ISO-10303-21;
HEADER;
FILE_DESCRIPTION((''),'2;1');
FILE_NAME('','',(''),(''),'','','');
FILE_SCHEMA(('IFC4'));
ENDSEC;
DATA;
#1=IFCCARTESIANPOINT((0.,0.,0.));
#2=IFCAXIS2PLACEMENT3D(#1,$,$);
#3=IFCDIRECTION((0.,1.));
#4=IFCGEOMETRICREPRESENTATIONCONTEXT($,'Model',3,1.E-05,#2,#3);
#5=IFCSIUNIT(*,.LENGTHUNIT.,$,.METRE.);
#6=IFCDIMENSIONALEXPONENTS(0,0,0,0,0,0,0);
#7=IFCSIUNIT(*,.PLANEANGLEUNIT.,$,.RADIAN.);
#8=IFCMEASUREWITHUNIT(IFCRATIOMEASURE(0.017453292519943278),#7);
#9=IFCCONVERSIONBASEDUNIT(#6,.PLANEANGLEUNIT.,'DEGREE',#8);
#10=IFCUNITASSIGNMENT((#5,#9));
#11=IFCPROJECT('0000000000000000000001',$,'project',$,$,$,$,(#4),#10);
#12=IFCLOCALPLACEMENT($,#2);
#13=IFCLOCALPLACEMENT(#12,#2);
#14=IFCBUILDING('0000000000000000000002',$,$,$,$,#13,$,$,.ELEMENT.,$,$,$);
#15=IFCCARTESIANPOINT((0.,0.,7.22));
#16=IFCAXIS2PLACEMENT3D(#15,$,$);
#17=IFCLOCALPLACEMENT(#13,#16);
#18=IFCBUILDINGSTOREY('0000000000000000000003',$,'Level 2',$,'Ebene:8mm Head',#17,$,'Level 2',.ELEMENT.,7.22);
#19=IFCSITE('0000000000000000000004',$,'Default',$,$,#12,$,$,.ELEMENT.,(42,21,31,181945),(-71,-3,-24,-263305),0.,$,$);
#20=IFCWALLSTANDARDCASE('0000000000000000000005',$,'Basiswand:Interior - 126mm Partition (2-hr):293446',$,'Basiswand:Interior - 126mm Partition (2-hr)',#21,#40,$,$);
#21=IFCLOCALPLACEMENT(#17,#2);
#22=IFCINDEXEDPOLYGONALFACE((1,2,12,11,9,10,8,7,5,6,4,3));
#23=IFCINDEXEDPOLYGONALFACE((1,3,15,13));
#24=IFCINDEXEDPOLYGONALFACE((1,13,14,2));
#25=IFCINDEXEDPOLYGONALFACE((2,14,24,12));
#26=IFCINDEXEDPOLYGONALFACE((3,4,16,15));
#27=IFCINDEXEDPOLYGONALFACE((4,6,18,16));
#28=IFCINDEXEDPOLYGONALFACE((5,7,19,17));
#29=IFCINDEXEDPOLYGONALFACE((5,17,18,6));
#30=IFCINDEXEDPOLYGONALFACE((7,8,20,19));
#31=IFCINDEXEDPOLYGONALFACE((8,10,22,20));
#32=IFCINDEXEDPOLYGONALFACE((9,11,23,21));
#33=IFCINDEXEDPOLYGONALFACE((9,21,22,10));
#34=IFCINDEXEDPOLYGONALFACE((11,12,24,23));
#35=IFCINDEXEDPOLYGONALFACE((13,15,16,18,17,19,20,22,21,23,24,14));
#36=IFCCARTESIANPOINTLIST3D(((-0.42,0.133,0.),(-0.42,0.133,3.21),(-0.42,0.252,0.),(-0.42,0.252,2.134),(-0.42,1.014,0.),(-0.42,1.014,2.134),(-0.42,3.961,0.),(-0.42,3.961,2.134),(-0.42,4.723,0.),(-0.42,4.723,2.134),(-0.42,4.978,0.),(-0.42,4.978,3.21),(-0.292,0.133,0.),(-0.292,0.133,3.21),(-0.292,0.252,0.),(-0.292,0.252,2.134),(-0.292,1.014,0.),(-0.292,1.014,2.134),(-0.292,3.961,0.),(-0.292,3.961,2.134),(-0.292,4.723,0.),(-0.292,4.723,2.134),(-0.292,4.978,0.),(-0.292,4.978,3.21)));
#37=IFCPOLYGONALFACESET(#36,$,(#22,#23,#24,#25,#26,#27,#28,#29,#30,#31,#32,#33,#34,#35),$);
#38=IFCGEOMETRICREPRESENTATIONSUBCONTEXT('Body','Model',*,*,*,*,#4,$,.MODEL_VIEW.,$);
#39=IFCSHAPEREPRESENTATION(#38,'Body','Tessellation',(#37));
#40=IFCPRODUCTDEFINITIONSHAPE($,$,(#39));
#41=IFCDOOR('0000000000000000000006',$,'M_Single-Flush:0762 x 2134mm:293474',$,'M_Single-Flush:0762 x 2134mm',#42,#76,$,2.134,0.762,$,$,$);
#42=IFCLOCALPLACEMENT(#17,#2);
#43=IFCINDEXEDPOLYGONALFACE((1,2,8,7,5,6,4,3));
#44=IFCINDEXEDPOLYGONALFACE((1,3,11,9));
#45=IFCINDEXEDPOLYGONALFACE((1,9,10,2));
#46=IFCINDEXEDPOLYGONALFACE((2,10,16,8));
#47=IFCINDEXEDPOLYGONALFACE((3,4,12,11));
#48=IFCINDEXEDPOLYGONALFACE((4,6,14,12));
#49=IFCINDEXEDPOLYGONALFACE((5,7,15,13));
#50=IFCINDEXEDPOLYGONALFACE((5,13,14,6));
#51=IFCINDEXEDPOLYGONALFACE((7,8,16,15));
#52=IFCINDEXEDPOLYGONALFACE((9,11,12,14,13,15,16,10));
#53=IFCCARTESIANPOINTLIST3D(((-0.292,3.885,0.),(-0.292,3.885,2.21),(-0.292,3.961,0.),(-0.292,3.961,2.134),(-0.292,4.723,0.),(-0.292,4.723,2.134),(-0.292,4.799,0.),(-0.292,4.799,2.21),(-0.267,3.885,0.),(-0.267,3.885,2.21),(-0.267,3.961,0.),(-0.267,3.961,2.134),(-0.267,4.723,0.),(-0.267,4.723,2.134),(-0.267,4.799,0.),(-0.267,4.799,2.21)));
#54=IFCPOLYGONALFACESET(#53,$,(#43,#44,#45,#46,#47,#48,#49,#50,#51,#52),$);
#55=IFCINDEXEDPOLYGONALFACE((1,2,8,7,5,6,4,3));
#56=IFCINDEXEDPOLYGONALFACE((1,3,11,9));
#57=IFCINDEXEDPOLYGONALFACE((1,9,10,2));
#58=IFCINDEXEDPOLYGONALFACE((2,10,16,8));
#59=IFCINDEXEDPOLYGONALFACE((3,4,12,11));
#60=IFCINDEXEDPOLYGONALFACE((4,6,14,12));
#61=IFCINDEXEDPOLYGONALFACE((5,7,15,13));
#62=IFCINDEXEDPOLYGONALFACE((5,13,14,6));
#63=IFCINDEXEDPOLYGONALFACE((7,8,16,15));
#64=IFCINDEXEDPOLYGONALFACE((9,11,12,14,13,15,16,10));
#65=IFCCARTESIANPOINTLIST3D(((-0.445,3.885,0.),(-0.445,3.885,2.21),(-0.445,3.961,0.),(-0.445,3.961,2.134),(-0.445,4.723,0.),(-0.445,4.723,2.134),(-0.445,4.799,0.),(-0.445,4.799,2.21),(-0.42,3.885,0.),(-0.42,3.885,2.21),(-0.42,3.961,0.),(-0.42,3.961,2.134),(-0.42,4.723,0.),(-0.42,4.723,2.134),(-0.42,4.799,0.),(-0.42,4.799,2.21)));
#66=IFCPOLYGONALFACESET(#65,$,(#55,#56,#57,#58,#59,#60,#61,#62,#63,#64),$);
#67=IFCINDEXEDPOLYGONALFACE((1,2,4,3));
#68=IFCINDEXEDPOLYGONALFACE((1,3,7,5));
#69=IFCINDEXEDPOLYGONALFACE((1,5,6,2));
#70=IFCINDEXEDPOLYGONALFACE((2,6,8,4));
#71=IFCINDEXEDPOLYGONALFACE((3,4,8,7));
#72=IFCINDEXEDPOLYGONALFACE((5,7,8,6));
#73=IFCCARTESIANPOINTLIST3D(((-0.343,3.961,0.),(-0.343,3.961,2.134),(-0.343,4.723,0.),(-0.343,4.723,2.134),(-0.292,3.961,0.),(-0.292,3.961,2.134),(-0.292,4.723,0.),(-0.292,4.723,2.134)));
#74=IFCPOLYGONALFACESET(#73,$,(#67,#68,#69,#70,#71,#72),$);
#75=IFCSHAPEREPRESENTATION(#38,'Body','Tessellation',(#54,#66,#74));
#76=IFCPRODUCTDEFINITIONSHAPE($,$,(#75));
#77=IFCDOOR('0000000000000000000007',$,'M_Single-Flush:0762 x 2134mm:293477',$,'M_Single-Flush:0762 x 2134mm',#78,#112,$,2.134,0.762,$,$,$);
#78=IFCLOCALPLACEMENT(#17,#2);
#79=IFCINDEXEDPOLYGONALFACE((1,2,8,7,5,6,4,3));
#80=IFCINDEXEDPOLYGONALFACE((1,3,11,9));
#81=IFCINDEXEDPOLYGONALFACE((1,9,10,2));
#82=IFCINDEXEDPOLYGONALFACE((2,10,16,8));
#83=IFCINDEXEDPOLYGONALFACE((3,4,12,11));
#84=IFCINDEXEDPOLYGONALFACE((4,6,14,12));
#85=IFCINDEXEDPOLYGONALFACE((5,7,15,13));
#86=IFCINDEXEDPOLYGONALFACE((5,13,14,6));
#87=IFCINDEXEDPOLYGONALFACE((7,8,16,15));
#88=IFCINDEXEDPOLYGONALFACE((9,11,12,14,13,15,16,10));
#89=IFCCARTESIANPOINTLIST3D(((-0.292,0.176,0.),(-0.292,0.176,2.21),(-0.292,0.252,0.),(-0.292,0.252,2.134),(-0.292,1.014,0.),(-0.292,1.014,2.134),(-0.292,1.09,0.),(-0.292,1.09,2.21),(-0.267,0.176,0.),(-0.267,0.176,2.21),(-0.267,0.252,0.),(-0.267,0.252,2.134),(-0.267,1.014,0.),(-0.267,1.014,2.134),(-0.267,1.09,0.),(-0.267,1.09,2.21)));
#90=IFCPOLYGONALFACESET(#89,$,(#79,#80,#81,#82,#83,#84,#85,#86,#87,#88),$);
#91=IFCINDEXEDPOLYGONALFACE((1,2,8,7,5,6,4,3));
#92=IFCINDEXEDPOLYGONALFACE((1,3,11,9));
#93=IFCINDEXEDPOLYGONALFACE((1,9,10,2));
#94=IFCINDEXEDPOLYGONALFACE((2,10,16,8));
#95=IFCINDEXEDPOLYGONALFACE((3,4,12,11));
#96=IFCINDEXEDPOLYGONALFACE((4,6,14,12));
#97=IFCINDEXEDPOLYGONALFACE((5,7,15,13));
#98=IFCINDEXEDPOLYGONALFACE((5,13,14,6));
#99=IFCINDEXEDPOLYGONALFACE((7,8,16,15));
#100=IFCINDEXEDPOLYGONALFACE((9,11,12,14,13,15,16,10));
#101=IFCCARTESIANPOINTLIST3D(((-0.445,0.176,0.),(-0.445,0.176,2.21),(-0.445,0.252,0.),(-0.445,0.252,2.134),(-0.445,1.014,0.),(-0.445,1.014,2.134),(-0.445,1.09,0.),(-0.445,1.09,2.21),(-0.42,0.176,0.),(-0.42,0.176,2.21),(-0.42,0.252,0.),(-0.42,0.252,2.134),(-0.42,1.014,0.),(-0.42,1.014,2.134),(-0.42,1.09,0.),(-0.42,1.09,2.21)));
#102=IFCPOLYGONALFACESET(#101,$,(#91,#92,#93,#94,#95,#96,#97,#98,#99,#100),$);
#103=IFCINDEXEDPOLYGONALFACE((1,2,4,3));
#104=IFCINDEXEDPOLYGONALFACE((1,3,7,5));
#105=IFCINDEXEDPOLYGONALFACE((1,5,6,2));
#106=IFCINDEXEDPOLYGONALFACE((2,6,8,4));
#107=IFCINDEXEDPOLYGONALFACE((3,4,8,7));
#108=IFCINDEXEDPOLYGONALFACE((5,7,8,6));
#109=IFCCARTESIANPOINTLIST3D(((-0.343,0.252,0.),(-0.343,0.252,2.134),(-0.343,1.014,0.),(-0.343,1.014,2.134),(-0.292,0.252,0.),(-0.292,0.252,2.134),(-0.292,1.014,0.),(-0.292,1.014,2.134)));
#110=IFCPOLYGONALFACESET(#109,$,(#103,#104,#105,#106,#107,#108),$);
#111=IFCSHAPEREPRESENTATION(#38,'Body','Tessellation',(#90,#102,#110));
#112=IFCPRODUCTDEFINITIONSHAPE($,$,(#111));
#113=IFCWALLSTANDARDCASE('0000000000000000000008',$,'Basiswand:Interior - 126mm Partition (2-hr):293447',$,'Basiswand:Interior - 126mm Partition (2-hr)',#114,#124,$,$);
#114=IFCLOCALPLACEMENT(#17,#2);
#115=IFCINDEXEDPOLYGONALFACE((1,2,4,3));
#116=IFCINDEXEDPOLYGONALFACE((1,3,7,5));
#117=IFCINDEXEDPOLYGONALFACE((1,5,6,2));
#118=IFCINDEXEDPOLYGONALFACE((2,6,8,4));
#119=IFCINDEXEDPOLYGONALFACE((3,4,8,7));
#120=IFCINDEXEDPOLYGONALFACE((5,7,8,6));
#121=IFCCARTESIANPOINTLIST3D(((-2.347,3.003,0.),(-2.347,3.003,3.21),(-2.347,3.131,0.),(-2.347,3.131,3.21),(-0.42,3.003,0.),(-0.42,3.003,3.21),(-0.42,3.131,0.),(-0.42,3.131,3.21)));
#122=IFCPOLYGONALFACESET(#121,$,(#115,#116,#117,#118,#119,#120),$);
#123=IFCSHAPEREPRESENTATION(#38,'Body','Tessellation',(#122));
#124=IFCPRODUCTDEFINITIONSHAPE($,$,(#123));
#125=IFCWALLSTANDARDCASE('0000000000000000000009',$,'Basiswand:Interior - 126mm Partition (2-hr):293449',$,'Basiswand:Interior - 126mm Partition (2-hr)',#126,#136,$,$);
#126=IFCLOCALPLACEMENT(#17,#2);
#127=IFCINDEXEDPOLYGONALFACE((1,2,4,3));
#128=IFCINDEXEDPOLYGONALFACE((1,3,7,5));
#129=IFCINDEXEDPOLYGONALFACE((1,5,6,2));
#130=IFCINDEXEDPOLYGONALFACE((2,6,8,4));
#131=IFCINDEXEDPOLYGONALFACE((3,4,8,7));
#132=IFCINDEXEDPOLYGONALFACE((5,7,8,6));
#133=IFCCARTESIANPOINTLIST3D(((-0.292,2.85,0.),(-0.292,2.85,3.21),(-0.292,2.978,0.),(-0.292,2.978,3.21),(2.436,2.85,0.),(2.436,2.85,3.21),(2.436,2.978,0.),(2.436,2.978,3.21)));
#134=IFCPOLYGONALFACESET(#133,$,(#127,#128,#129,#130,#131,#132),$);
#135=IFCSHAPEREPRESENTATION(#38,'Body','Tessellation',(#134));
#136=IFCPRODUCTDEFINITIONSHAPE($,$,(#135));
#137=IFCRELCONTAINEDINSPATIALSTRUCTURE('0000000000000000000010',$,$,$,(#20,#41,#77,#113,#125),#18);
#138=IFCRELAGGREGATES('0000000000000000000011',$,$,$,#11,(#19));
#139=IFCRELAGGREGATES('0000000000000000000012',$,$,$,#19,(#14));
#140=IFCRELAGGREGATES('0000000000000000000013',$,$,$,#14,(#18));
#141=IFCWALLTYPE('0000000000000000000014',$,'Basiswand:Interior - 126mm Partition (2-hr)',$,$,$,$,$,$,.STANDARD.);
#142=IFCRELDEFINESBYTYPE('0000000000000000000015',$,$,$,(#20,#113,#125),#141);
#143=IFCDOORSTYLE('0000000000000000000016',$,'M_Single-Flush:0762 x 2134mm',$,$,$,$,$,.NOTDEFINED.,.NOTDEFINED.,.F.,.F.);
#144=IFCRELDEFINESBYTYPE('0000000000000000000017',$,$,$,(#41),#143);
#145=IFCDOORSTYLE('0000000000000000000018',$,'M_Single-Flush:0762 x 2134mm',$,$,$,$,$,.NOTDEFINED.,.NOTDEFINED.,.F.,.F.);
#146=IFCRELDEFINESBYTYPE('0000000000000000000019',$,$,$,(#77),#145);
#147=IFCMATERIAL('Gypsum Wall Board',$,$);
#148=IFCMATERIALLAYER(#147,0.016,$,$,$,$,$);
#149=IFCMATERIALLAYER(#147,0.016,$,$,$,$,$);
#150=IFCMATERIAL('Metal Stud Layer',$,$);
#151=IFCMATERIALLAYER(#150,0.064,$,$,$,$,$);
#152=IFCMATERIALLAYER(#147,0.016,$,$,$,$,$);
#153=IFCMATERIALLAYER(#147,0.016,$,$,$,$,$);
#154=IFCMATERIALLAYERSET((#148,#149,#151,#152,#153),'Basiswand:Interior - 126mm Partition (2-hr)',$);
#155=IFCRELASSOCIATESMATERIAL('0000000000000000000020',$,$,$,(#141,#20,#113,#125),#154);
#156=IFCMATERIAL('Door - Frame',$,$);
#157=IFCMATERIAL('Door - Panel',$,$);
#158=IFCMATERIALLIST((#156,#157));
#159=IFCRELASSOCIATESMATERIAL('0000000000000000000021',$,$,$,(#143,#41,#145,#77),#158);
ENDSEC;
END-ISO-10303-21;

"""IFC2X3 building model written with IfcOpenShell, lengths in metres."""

from ifc_helpers import new_model, entity, si_unit, converted_unit, direction, frame, frame_2d, origin, place, context, subcontext, project, spatial, polyline, rectangle, outline, extrude, clip, bounded_halfspace, source, transform, mapped, material, material_list, layer, layer_set, layer_usage, type_object, type_shapes, element, fill, save


model = new_model("IFC2X3")

# Units and contexts
model_context = context("Model", 3, precision=1e-05, world=origin(), true_north=direction((0.0, 1.0)))
body_context = subcontext(model_context, "Body", "Model", "MODEL_VIEW")
ifc_project = project(units=[si_unit("LENGTHUNIT", "METRE"), converted_unit("PLANEANGLEUNIT", "DEGREE", entity("IfcRatioMeasure", 0.017453292519943278), si_unit("PLANEANGLEUNIT", "RADIAN"), dimensions=[0, 0, 0, 0, 0, 0, 0])], contexts=[model_context])

# Site, building, storey
site_placement = place(None, origin())
site = spatial("IfcSite", under=ifc_project, at=site_placement, Name="Default", CompositionType="ELEMENT", RefLatitude=(42, 21, 31, 181945), RefLongitude=(-71, -3, -24, -263305), RefElevation=0.0)
building_placement = place(site_placement, origin())
building = spatial("IfcBuilding", under=site, at=building_placement, CompositionType="ELEMENT")
storey_placement = place(building_placement, frame((0.0, 0.0, 7.22)))
storey = spatial("IfcBuildingStorey", under=building, at=storey_placement, Name="Level 2", ObjectType="Ebene:8mm Head", LongName="Level 2", CompositionType="ELEMENT", Elevation=7.22)

# Shared definitions
ifc_material_1 = material(Name="Gypsum Wall Board")
ifc_layer_1 = layer(ifc_material_1, 0.016)
ifc_layer_2 = layer(ifc_material_1, 0.016)
ifc_material_2 = material(Name="Metal Stud Layer")
ifc_layer_3 = layer(ifc_material_2, 0.064)
ifc_layer_4 = layer(ifc_material_1, 0.016)
ifc_layer_5 = layer(ifc_material_1, 0.016)
ifc_layer_set = layer_set([ifc_layer_1, ifc_layer_2, ifc_layer_3, ifc_layer_4, ifc_layer_5], Name="Basiswand:Interior - 126mm Partition (2-hr)")
ifc_layer_usage_1 = layer_usage(ifc_layer_set, "AXIS2", "NEGATIVE", 0.064)
wall_type = type_object("IfcWallType", Name="Basiswand:Interior - 126mm Partition (2-hr)", PredefinedType="STANDARD", material=ifc_layer_set)
ifc_material_3 = material(Name="Door - Frame")
ifc_material_4 = material(Name="Door - Panel")
ifc_material_list = material_list([ifc_material_3, ifc_material_4])
door_style_1 = type_object("IfcDoorStyle", Name="M_Single-Flush:0762 x 2134mm", ConstructionType="NOTDEFINED", OperationType="NOTDEFINED", ParameterTakesPrecedence=False, Sizeable=False, material=ifc_material_list)
shared_shape_1 = source(origin(), body_context, "Body", "SweptSolid", [
    extrude(outline(polyline([(-0.457, -1.124), (0.457, -1.124), (0.457, 1.086), (0.381, 1.086), (0.381, -1.048), (-0.381, -1.048), (-0.381, 1.086), (-0.457, 1.086), (-0.457, -1.124)])), frame((0.381, 0.153, 1.086), z_axis=(0.0, -1.0, 0.0), x_axis=(-1.0, 0.0, 0.0)), (0.0, 0.0, 1.0), 0.025),
    extrude(outline(polyline([(-1.124, -0.457), (1.086, -0.457), (1.086, -0.381), (-1.048, -0.381), (-1.048, 0.381), (1.086, 0.381), (1.086, 0.457), (-1.124, 0.457), (-1.124, -0.457)])), frame((0.381, 0.0, 1.086), z_axis=(0.0, -1.0, 0.0), x_axis=(0.0, 0.0, -1.0)), (0.0, 0.0, 1.0), 0.025),
    extrude(rectangle(XDim=0.762, YDim=0.051, at=frame_2d((0.0, 0.0), x_axis=(1.0, 0.0))), frame((0.381, 0.1025, 0.0)), (0.0, 0.0, 1.0), 2.134),
])
type_shapes(door_style_1, [shared_shape_1])

# Wall, openings, doors
ifc_layer_usage_2 = layer_usage(ifc_layer_set, "AXIS2", "POSITIVE", -0.064)
wall_1_placement = place(storey_placement, frame((-0.356, 4.978, 0.0), z_axis=(0.0, 0.0, 1.0), x_axis=(0.0, -1.0, 0.0)))
wall_1 = element("IfcWallStandardCase", 1, at=wall_1_placement, inside=storey, type_object=wall_type, material=ifc_layer_usage_2, Name="Basiswand:Interior - 126mm Partition (2-hr):293446", ObjectType="Basiswand:Interior - 126mm Partition (2-hr)", context=body_context, shape_type="Clipping", body=[
    clip(extrude(rectangle(XDim=4.845, YDim=0.128, at=frame_2d((2.4225, 0.0), x_axis=(1.0, 0.0))), origin(), (0.0, 0.0, 1.0), 3.21), bounded_halfspace(frame((0.0, -0.064, 3.21), z_axis=(0.0, 0.0, -1.0), x_axis=(-1.0, 0.0, 0.0)), True, frame((0.0, -0.064, 3.21)), polyline([(0.0, 0.0), (1.847, 0.0), (1.975, 0.0), (2.975, 0.0), (3.103, 0.0), (4.845, 0.0), (4.845, 0.128), (2.128, 0.128), (2.0, 0.128), (0.0, 0.128), (0.0, 0.0)]))),
])
opening_1_placement = place(wall_1_placement, frame((0.255, -0.064, 0.0)))
opening_1 = element("IfcOpeningElement", 2, at=opening_1_placement, cuts=wall_1, ObjectType="Opening", context=body_context, shape_type="SweptSolid", body=[
    extrude(rectangle(XDim=0.762, YDim=2.134, at=frame_2d((1.067, 0.381), x_axis=(0.0, -1.0))), frame((0.0, 0.0, 0.0), z_axis=(0.0, 1.0, 0.0), x_axis=(0.0, 0.0, 1.0)), (0.0, 0.0, 1.0), 0.128),
])
opening_2_placement = place(wall_1_placement, frame((3.964, -0.064, 0.0)))
opening_2 = element("IfcOpeningElement", 3, at=opening_2_placement, cuts=wall_1, ObjectType="Opening", context=body_context, shape_type="SweptSolid", body=[
    extrude(rectangle(XDim=0.762, YDim=2.134, at=frame_2d((1.067, 0.381), x_axis=(0.0, 1.0))), frame((0.0, 0.0, 0.0), z_axis=(0.0, 1.0, 0.0), x_axis=(0.0, 0.0, 1.0)), (0.0, 0.0, 1.0), 0.128),
])
door_1_placement = place(opening_1_placement, origin())
door_1 = element("IfcDoor", 4, at=door_1_placement, inside=storey, type_object=door_style_1, material=ifc_material_list, Name="M_Single-Flush:0762 x 2134mm:293474", ObjectType="M_Single-Flush:0762 x 2134mm", OverallHeight=2.134, OverallWidth=0.762, context=body_context, shape_type="MappedRepresentation", body=[
    mapped(shared_shape_1, transform((0.0, 0.0, 0.0), scale=1.0)),
])
fill(opening_1, door_1)
door_style_2 = type_object("IfcDoorStyle", Name="M_Single-Flush:0762 x 2134mm", ConstructionType="NOTDEFINED", OperationType="NOTDEFINED", ParameterTakesPrecedence=False, Sizeable=False, material=ifc_material_list)
shared_shape_2 = source(origin(), body_context, "Body", "SweptSolid", [
    extrude(outline(polyline([(-0.457, -1.124), (0.457, -1.124), (0.457, 1.086), (0.381, 1.086), (0.381, -1.048), (-0.381, -1.048), (-0.381, 1.086), (-0.457, 1.086), (-0.457, -1.124)])), frame((0.381, 0.128, 1.086), z_axis=(0.0, 1.0, 0.0), x_axis=(1.0, 0.0, 0.0)), (0.0, 0.0, 1.0), 0.025),
    extrude(outline(polyline([(-1.124, -0.457), (1.086, -0.457), (1.086, -0.381), (-1.048, -0.381), (-1.048, 0.381), (1.086, 0.381), (1.086, 0.457), (-1.124, 0.457), (-1.124, -0.457)])), frame((0.381, -0.025, 1.086), z_axis=(0.0, 1.0, 0.0), x_axis=(0.0, 0.0, -1.0)), (0.0, 0.0, 1.0), 0.025),
    extrude(rectangle(XDim=0.051, YDim=0.762, at=frame_2d((0.0, 0.0), x_axis=(1.0, 0.0))), frame((0.381, 0.1025, 0.0), z_axis=(0.0, 0.0, 1.0), x_axis=(0.0, 1.0, 0.0)), (0.0, 0.0, 1.0), 2.134),
])
type_shapes(door_style_2, [shared_shape_2])
door_2_placement = place(opening_2_placement, origin())
door_2 = element("IfcDoor", 5, at=door_2_placement, inside=storey, type_object=door_style_2, material=ifc_material_list, Name="M_Single-Flush:0762 x 2134mm:293477", ObjectType="M_Single-Flush:0762 x 2134mm", OverallHeight=2.134, OverallWidth=0.762, context=body_context, shape_type="MappedRepresentation", body=[
    mapped(shared_shape_2, transform((0.0, 0.0, 0.0), scale=1.0)),
])
fill(opening_2, door_2)

# Walls
wall_2_placement = place(storey_placement, frame((-2.347, 3.067, 0.0)))
element("IfcWallStandardCase", 6, at=wall_2_placement, inside=storey, type_object=wall_type, material=ifc_layer_usage_1, Name="Basiswand:Interior - 126mm Partition (2-hr):293447", ObjectType="Basiswand:Interior - 126mm Partition (2-hr)", context=body_context, shape_type="Clipping", body=[
    clip(extrude(rectangle(XDim=1.927, YDim=0.128, at=frame_2d((0.9635, 0.0), x_axis=(-1.0, 0.0))), origin(), (0.0, 0.0, 1.0), 3.21), bounded_halfspace(frame((0.0, -0.064, 3.21), z_axis=(0.0, 0.0, -1.0), x_axis=(0.0, 1.0, 0.0)), True, frame((0.0, -0.064, 3.21)), polyline([(0.0, 0.0), (1.927, 0.0), (1.927, 0.128), (0.0, 0.128), (0.0, 0.0)]))),
])
wall_3_placement = place(storey_placement, frame((-0.292, 2.914, 0.0)))
element("IfcWallStandardCase", 7, at=wall_3_placement, inside=storey, type_object=wall_type, material=ifc_layer_usage_1, Name="Basiswand:Interior - 126mm Partition (2-hr):293449", ObjectType="Basiswand:Interior - 126mm Partition (2-hr)", context=body_context, shape_type="Clipping", body=[
    clip(extrude(rectangle(XDim=2.728, YDim=0.128, at=frame_2d((1.364, 0.0), x_axis=(-1.0, 0.0))), origin(), (0.0, 0.0, 1.0), 3.21), bounded_halfspace(frame((0.0, -0.064, 3.21), z_axis=(0.0, 0.0, -1.0), x_axis=(0.0, 1.0, 0.0)), True, frame((0.0, -0.064, 3.21)), polyline([(0.0, 0.0), (2.728, 0.0), (2.728, 0.128), (0.0, 0.128), (0.0, 0.0)]))),
])

save(model, "model.ifc")
